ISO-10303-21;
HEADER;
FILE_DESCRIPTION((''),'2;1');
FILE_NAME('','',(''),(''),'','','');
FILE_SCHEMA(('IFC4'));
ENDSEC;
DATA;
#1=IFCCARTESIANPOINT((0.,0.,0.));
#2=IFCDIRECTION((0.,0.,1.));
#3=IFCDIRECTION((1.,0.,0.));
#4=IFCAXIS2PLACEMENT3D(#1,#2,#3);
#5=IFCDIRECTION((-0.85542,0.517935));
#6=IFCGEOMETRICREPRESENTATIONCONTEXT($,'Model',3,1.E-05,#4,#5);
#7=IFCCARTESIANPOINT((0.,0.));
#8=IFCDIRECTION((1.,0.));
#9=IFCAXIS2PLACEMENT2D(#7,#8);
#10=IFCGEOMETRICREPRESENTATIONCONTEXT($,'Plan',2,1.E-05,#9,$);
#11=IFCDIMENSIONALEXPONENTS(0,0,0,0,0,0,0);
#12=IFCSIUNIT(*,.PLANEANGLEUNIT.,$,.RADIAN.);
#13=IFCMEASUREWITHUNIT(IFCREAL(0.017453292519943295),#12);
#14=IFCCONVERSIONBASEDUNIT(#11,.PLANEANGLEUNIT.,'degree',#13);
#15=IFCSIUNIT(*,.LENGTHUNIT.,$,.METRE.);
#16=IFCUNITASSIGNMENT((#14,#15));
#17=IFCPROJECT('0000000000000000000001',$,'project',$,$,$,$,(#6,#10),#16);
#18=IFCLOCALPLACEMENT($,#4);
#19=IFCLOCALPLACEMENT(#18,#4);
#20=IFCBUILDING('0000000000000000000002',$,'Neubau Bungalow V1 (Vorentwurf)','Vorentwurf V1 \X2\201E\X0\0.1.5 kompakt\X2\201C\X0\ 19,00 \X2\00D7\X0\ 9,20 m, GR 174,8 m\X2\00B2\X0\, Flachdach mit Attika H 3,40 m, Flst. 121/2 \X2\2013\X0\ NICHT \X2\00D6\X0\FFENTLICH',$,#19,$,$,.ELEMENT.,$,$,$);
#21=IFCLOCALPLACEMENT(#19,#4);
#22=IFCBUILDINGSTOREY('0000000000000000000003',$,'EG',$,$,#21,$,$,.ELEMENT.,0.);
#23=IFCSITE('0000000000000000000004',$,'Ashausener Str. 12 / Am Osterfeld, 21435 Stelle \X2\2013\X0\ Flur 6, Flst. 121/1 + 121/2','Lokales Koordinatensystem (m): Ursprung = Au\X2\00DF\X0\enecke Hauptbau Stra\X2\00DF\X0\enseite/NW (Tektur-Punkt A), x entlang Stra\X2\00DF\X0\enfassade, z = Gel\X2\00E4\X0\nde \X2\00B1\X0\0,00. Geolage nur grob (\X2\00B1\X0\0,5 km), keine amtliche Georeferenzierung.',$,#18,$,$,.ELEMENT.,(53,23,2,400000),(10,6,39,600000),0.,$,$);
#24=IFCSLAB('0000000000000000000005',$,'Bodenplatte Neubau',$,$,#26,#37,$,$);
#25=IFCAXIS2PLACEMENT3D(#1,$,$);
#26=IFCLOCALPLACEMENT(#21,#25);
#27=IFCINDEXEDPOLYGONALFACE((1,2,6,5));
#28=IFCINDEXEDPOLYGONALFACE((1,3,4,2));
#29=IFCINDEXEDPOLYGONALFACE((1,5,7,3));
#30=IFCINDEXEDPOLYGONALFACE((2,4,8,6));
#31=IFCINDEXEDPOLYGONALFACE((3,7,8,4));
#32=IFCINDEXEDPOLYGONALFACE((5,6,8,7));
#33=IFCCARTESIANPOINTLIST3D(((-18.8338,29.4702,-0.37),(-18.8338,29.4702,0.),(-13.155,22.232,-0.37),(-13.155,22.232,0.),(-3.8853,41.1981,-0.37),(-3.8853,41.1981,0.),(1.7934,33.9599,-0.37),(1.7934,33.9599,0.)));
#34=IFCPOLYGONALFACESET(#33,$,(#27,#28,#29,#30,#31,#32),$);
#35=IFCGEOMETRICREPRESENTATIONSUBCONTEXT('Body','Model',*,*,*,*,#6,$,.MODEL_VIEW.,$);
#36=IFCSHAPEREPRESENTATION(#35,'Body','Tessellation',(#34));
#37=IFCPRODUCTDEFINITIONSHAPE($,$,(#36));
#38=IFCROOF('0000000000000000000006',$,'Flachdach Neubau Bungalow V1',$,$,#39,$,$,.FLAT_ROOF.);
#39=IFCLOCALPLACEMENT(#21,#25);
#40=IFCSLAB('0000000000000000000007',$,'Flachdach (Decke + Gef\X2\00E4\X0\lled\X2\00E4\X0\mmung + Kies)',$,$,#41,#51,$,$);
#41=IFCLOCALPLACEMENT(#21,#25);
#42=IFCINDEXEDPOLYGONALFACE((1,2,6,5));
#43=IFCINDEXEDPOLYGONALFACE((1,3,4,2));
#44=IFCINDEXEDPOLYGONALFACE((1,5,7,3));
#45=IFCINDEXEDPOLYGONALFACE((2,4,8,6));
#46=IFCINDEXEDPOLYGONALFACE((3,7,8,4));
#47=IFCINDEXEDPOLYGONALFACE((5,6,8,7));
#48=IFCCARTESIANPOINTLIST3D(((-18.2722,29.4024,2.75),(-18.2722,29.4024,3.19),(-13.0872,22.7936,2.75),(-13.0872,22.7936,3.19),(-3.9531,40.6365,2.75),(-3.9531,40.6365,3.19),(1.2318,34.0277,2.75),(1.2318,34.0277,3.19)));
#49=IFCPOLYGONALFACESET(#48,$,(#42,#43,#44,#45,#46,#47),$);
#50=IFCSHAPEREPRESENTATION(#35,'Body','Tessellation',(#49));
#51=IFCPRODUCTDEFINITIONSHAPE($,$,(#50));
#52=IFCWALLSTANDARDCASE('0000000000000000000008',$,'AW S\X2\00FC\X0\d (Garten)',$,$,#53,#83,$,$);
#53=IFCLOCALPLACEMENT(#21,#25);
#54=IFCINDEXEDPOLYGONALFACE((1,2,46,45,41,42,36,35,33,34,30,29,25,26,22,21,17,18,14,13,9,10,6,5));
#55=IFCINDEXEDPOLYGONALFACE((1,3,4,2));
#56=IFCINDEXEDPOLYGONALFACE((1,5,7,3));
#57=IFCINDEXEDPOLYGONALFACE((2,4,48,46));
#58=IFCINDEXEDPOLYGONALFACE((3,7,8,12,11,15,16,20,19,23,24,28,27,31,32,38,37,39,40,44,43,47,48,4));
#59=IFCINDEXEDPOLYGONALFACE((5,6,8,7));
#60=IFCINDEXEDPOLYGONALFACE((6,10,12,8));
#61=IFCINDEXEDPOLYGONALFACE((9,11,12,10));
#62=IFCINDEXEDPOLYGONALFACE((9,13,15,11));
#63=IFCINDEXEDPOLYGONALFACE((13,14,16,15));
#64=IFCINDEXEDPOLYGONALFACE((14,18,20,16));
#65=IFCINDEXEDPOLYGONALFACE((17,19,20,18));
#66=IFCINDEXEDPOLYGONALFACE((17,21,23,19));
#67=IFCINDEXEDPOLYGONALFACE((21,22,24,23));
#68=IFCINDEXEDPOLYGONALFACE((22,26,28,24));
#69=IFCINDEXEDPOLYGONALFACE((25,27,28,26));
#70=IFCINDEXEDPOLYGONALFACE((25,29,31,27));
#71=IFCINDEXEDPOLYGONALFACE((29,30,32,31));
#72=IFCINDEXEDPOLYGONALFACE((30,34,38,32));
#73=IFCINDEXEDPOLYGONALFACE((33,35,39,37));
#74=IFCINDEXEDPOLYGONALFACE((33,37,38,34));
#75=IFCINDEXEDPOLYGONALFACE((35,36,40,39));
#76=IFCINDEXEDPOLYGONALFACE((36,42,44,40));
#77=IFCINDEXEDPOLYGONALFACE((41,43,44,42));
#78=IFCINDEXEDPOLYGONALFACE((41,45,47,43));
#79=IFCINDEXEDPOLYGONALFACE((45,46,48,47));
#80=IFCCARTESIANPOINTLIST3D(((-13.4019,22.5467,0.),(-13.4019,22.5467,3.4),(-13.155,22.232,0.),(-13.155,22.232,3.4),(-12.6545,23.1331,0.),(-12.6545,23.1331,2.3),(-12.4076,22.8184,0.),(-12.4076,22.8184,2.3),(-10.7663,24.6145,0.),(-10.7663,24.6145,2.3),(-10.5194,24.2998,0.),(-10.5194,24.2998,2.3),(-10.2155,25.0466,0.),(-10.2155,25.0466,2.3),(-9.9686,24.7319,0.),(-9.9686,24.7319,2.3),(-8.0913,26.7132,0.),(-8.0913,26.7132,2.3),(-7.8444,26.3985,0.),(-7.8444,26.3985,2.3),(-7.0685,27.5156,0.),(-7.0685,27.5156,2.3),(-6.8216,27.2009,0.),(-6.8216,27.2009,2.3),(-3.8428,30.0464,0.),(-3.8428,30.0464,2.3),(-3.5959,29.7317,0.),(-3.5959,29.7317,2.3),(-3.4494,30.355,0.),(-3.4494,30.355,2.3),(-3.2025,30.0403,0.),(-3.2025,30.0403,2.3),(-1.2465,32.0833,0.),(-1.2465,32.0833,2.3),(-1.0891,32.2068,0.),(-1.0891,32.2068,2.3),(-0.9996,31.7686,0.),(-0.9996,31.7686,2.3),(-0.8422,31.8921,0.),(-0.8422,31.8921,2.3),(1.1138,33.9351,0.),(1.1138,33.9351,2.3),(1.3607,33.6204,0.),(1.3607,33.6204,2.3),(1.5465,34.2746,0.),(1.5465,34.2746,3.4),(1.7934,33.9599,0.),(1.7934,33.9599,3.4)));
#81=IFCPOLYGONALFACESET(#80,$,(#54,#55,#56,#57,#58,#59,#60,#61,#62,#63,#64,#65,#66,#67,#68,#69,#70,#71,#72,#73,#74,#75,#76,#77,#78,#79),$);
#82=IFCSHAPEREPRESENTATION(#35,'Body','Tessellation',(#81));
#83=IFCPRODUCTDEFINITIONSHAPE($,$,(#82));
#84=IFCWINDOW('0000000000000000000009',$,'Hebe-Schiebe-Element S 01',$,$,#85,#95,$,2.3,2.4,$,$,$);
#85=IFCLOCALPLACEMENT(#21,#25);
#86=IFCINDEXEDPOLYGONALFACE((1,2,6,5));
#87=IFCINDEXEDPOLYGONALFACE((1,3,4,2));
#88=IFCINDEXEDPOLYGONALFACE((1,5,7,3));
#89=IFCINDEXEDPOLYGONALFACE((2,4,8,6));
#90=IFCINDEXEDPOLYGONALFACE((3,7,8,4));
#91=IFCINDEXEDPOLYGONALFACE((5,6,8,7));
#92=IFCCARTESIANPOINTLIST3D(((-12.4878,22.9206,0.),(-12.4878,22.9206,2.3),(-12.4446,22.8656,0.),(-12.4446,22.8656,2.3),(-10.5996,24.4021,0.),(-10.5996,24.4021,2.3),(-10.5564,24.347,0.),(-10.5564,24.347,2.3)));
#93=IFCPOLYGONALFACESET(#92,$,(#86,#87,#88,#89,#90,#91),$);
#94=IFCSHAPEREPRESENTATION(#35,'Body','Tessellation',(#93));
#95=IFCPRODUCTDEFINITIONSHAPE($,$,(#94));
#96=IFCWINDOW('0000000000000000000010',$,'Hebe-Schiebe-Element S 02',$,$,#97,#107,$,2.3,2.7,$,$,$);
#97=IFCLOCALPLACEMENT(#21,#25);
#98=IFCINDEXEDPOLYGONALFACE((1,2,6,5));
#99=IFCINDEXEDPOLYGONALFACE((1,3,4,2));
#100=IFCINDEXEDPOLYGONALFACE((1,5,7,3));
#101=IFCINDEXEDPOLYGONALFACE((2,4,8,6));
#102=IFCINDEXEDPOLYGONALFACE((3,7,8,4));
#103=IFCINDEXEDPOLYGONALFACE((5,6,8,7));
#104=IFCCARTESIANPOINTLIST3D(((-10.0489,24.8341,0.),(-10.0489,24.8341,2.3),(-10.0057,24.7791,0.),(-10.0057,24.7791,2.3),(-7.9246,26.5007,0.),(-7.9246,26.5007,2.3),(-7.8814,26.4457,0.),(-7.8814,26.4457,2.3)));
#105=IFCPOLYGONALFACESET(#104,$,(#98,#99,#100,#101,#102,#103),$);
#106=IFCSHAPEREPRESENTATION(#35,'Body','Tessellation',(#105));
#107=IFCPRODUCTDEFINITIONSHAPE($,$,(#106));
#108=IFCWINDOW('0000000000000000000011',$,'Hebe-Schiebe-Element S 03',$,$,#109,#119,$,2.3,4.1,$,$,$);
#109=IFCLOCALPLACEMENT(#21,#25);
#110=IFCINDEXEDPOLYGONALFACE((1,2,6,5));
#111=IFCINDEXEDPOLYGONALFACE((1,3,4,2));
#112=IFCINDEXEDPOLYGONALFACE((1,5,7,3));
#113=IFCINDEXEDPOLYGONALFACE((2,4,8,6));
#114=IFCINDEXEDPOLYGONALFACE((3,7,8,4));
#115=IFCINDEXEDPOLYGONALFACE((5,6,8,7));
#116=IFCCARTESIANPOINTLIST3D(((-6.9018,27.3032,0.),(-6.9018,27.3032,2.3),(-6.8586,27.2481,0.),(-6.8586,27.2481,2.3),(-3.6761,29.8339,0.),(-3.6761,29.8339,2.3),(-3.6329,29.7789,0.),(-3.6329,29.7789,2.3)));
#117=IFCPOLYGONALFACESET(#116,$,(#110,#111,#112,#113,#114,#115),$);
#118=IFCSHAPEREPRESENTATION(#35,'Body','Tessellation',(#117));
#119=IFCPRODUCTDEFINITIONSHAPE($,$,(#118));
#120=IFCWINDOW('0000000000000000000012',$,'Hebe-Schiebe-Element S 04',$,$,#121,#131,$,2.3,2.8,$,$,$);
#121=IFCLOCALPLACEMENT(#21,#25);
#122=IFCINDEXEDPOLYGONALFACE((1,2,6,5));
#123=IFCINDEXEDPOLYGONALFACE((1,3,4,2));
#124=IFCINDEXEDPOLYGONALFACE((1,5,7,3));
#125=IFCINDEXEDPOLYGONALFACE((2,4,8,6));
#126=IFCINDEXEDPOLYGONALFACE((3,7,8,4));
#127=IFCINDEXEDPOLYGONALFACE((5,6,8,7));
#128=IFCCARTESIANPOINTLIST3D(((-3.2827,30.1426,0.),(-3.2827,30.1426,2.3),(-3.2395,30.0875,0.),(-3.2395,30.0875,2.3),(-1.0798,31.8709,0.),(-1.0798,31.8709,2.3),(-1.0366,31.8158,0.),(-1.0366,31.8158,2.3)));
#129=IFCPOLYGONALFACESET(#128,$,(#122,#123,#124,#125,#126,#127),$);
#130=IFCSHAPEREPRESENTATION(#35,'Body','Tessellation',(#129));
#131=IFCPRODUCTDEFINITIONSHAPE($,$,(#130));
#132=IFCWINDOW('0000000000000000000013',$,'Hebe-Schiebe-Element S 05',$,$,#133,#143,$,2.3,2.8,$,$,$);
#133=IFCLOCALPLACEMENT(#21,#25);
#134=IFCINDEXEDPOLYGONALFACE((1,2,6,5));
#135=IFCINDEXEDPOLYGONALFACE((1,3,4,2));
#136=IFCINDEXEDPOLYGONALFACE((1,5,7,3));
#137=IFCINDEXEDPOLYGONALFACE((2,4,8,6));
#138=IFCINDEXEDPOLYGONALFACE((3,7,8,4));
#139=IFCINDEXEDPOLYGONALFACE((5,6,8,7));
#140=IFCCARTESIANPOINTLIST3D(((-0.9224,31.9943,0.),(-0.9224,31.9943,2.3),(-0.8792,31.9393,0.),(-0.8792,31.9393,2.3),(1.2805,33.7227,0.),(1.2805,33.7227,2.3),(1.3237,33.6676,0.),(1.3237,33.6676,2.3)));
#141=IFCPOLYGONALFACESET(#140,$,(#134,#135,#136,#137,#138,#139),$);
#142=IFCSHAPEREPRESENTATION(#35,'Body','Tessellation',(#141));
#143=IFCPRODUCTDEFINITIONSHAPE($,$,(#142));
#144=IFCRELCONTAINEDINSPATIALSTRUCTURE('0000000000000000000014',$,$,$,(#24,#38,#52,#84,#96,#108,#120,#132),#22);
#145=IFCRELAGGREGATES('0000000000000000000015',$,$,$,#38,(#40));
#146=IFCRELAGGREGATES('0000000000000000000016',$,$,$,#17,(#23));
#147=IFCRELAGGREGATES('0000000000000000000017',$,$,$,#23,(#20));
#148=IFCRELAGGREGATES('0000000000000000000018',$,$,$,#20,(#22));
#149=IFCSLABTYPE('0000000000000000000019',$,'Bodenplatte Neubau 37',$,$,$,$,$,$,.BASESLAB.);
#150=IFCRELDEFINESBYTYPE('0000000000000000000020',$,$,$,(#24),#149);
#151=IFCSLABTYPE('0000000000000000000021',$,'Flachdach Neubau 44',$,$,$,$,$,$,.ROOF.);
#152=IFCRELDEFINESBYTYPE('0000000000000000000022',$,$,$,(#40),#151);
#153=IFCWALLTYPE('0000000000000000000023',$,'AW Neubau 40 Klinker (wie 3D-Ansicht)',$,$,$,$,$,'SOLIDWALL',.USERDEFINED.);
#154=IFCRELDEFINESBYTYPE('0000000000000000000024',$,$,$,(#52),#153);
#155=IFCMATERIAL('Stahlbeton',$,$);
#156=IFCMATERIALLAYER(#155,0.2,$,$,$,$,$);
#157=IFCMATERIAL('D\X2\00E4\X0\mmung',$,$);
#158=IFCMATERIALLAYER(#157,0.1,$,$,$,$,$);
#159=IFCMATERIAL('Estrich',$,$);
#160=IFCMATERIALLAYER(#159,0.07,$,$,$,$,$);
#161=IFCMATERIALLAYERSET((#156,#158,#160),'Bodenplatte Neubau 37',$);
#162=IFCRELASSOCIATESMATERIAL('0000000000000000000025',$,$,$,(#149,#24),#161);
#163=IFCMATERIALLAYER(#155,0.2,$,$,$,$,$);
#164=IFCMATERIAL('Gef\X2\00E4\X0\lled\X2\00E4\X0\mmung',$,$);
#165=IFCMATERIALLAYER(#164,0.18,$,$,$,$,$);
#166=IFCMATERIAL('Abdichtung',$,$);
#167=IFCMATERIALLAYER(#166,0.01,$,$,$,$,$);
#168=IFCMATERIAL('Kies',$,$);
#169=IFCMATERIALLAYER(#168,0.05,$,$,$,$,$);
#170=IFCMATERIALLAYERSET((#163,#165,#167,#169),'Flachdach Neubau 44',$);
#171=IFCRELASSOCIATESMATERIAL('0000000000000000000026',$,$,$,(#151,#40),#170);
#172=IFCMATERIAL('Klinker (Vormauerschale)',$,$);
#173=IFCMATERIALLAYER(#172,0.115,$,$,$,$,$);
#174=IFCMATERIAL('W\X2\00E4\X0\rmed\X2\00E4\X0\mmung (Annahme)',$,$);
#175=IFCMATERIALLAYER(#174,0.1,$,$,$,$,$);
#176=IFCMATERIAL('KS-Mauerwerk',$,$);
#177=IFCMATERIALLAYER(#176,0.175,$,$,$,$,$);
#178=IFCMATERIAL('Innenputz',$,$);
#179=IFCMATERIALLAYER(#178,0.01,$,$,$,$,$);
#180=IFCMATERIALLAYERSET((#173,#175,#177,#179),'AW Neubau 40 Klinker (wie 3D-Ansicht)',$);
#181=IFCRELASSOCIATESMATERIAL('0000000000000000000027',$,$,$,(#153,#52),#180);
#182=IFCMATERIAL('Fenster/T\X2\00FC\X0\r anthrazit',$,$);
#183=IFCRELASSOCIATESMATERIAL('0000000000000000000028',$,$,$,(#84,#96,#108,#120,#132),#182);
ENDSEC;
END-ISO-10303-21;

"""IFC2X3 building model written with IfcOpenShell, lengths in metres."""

from ifc_helpers import new_model, entity, si_unit, converted_unit, direction, frame, origin_with_axes, origin_2d_with_axis, place, context, subcontext, project, spatial, polyline, outline, extrude, material, layer, layer_set, layer_usage, type_object, element, fill, aggregate, save


model = new_model("IFC2X3")

# Units and contexts
model_context = context("Model", 3, precision=1e-05, world=origin_with_axes(), true_north=direction((-0.85542, 0.517935)))
plan_context = context("Plan", 2, precision=1e-05, world=origin_2d_with_axis())
body_context = subcontext(model_context, "Body", "Model", "MODEL_VIEW")
ifc_project = project(units=[converted_unit("PLANEANGLEUNIT", "degree", entity("IfcReal", 0.017453292519943295), si_unit("PLANEANGLEUNIT", "RADIAN"), dimensions=[0, 0, 0, 0, 0, 0, 0]), si_unit("LENGTHUNIT", "METRE")], contexts=[model_context, plan_context])

# Site, building, storey
site_placement = place(None, origin_with_axes())
site = spatial("IfcSite", under=ifc_project, at=site_placement, Name="Ashausener Str. 12 / Am Osterfeld, 21435 Stelle – Flur 6, Flst. 121/1 + 121/2", Description="Lokales Koordinatensystem (m): Ursprung = Außenecke Hauptbau Straßenseite/NW (Tektur-Punkt A), x entlang Straßenfassade, z = Gelände ±0,00. Geolage nur grob (±0,5 km), keine amtliche Georeferenzierung.", CompositionType="ELEMENT", RefLatitude=(53, 23, 2, 400000), RefLongitude=(10, 6, 39, 600000), RefElevation=0.0)
building_placement = place(site_placement, origin_with_axes())
building = spatial("IfcBuilding", under=site, at=building_placement, Name="Neubau Bungalow V1 (Vorentwurf)", Description="Vorentwurf V1 „0.1.5 kompakt“ 19,00 × 9,20 m, GR 174,8 m², Flachdach mit Attika H 3,40 m, Flst. 121/2 – NICHT ÖFFENTLICH", CompositionType="ELEMENT")
storey_placement = place(building_placement, origin_with_axes())
storey = spatial("IfcBuildingStorey", under=building, at=storey_placement, Name="EG", CompositionType="ELEMENT", Elevation=0.0)

# Slab
ifc_material_1 = material(Name="Stahlbeton")
ifc_layer_1 = layer(ifc_material_1, 0.2)
ifc_material_2 = material(Name="Dämmung")
ifc_layer_2 = layer(ifc_material_2, 0.1)
ifc_material_3 = material(Name="Estrich")
ifc_layer_3 = layer(ifc_material_3, 0.07)
ifc_layer_set_1 = layer_set([ifc_layer_1, ifc_layer_2, ifc_layer_3], Name="Bodenplatte Neubau 37")
ifc_layer_usage_1 = layer_usage(ifc_layer_set_1, "AXIS3", "POSITIVE", 0.0)
slab_type_1 = type_object("IfcSlabType", Name="Bodenplatte Neubau 37", PredefinedType="BASESLAB", material=ifc_layer_set_1)
slab_1_placement = place(storey_placement, origin_with_axes())
element("IfcSlab", 1, at=slab_1_placement, inside=storey, type_object=slab_type_1, material=ifc_layer_usage_1, Name="Bodenplatte Neubau", context=body_context, shape_type="SweptSolid", body=[
    extrude(outline(polyline([(-13.155, 22.232), (1.7934, 33.9599), (-3.8853, 41.1981), (-18.8338, 29.4702), (-13.155, 22.232)])), frame((0.0, 0.0, -0.37)), (0.0, 0.0, 1.0), 0.37),
])

# Roof, slab
roof_placement = place(storey_placement, origin_with_axes())
roof = element("IfcRoof", 2, at=roof_placement, inside=storey, Name="Flachdach Neubau Bungalow V1", ShapeType="FLAT_ROOF")
ifc_layer_4 = layer(ifc_material_1, 0.2)
ifc_material_4 = material(Name="Gefälledämmung")
ifc_layer_5 = layer(ifc_material_4, 0.18)
ifc_material_5 = material(Name="Abdichtung")
ifc_layer_6 = layer(ifc_material_5, 0.01)
ifc_material_6 = material(Name="Kies")
ifc_layer_7 = layer(ifc_material_6, 0.05)
ifc_layer_set_2 = layer_set([ifc_layer_4, ifc_layer_5, ifc_layer_6, ifc_layer_7], Name="Flachdach Neubau 44")
ifc_layer_usage_2 = layer_usage(ifc_layer_set_2, "AXIS3", "POSITIVE", 0.0)
slab_type_2 = type_object("IfcSlabType", Name="Flachdach Neubau 44", PredefinedType="ROOF", material=ifc_layer_set_2)
slab_2_placement = place(roof_placement, origin_with_axes())
slab_2 = element("IfcSlab", 3, at=slab_2_placement, type_object=slab_type_2, material=ifc_layer_usage_2, Name="Flachdach (Decke + Gefälledämmung + Kies)", context=body_context, shape_type="SweptSolid", body=[
    extrude(outline(polyline([(-13.0872, 22.7936), (1.2318, 34.0277), (-3.9531, 40.6365), (-18.2722, 29.4024), (-13.0872, 22.7936)])), frame((0.0, 0.0, 2.75)), (0.0, 0.0, 1.0), 0.44),
])
aggregate(roof, [slab_2])

# Wall, openings, windows
ifc_material_7 = material(Name="Klinker (Vormauerschale)")
ifc_layer_8 = layer(ifc_material_7, 0.115)
ifc_material_8 = material(Name="Wärmedämmung (Annahme)")
ifc_layer_9 = layer(ifc_material_8, 0.1)
ifc_material_9 = material(Name="KS-Mauerwerk")
ifc_layer_10 = layer(ifc_material_9, 0.175)
ifc_material_10 = material(Name="Innenputz")
ifc_layer_11 = layer(ifc_material_10, 0.01)
ifc_layer_set_3 = layer_set([ifc_layer_8, ifc_layer_9, ifc_layer_10, ifc_layer_11], Name="AW Neubau 40 Klinker (wie 3D-Ansicht)")
ifc_layer_usage_3 = layer_usage(ifc_layer_set_3, "AXIS2", "POSITIVE", 0.0)
wall_type_1 = type_object("IfcWallType", Name="AW Neubau 40 Klinker (wie 3D-Ansicht)", ElementType="SOLIDWALL", PredefinedType="USERDEFINED", material=ifc_layer_set_3)
wall_1_placement = place(storey_placement, frame((-13.155, 22.232, 0.0), z_axis=(0.0, 0.0, 1.0), x_axis=(0.786761, 0.617258, 0.0)))
wall_1 = element("IfcWallStandardCase", 4, at=wall_1_placement, inside=storey, type_object=wall_type_1, material=ifc_layer_usage_3, Name="AW Süd (Garten)", context=body_context, shape_type="SweptSolid", body=[
    extrude(outline(polyline([(0.0, 0.0), (0.0, 0.4), (19.0, 0.4), (19.0, 0.0), (0.0, 0.0)])), origin_with_axes(), (0.0, 0.0, 1.0), 3.4),
])
opening_1_placement = place(wall_1_placement, frame((0.95, -0.1, 0.0), z_axis=(0.0, 0.0, 1.0), x_axis=(1.0, 0.0, 0.0)))
opening_1 = element("IfcOpeningElement", 5, at=opening_1_placement, cuts=wall_1, context=body_context, shape_type="SweptSolid", body=[
    extrude(outline(polyline([(0.0, 0.0), (0.0, 0.6), (2.4, 0.6), (2.4, 0.0), (0.0, 0.0)])), origin_with_axes(), (0.0, 0.0, 1.0), 2.3),
])
opening_2_placement = place(wall_1_placement, frame((4.05, -0.1, 0.0), z_axis=(0.0, 0.0, 1.0), x_axis=(1.0, 0.0, 0.0)))
opening_2 = element("IfcOpeningElement", 6, at=opening_2_placement, cuts=wall_1, context=body_context, shape_type="SweptSolid", body=[
    extrude(outline(polyline([(0.0, 0.0), (0.0, 0.6), (2.7, 0.6), (2.7, 0.0), (0.0, 0.0)])), origin_with_axes(), (0.0, 0.0, 1.0), 2.3),
])
opening_3_placement = place(wall_1_placement, frame((8.05, -0.1, 0.0), z_axis=(0.0, 0.0, 1.0), x_axis=(1.0, 0.0, 0.0)))
opening_3 = element("IfcOpeningElement", 7, at=opening_3_placement, cuts=wall_1, context=body_context, shape_type="SweptSolid", body=[
    extrude(outline(polyline([(0.0, 0.0), (0.0, 0.6), (4.1, 0.6), (4.1, 0.0), (0.0, 0.0)])), origin_with_axes(), (0.0, 0.0, 1.0), 2.3),
])
opening_4_placement = place(wall_1_placement, frame((12.65, -0.1, 0.0), z_axis=(0.0, 0.0, 1.0), x_axis=(1.0, 0.0, 0.0)))
opening_4 = element("IfcOpeningElement", 8, at=opening_4_placement, cuts=wall_1, context=body_context, shape_type="SweptSolid", body=[
    extrude(outline(polyline([(0.0, 0.0), (0.0, 0.6), (2.8, 0.6), (2.8, 0.0), (0.0, 0.0)])), origin_with_axes(), (0.0, 0.0, 1.0), 2.3),
])
opening_5_placement = place(wall_1_placement, frame((15.65, -0.1, 0.0), z_axis=(0.0, 0.0, 1.0), x_axis=(1.0, 0.0, 0.0)))
opening_5 = element("IfcOpeningElement", 9, at=opening_5_placement, cuts=wall_1, context=body_context, shape_type="SweptSolid", body=[
    extrude(outline(polyline([(0.0, 0.0), (0.0, 0.6), (2.8, 0.6), (2.8, 0.0), (0.0, 0.0)])), origin_with_axes(), (0.0, 0.0, 1.0), 2.3),
])
ifc_material_11 = material(Name="Fenster/Tür anthrazit")
window_1_placement = place(storey_placement, frame((-12.4446, 22.8656, 0.0), z_axis=(0.0, 0.0, 1.0), x_axis=(0.786761, 0.617258, 0.0)))
window_1 = element("IfcWindow", 10, at=window_1_placement, inside=storey, material=ifc_material_11, Name="Hebe-Schiebe-Element S 01", OverallHeight=2.3, OverallWidth=2.4, context=body_context, shape_type="SweptSolid", body=[
    extrude(outline(polyline([(0.0, 0.0), (0.0, 0.07), (2.4, 0.07), (2.4, 0.0), (0.0, 0.0)])), origin_with_axes(), (0.0, 0.0, 1.0), 2.3),
])
fill(opening_1, window_1)
window_2_placement = place(storey_placement, frame((-10.0057, 24.7791, 0.0), z_axis=(0.0, 0.0, 1.0), x_axis=(0.786761, 0.617258, 0.0)))
window_2 = element("IfcWindow", 11, at=window_2_placement, inside=storey, material=ifc_material_11, Name="Hebe-Schiebe-Element S 02", OverallHeight=2.3, OverallWidth=2.7, context=body_context, shape_type="SweptSolid", body=[
    extrude(outline(polyline([(0.0, 0.0), (0.0, 0.07), (2.7, 0.07), (2.7, 0.0), (0.0, 0.0)])), origin_with_axes(), (0.0, 0.0, 1.0), 2.3),
])
fill(opening_2, window_2)
window_3_placement = place(storey_placement, frame((-6.8586, 27.2481, 0.0), z_axis=(0.0, 0.0, 1.0), x_axis=(0.786761, 0.617258, 0.0)))
window_3 = element("IfcWindow", 12, at=window_3_placement, inside=storey, material=ifc_material_11, Name="Hebe-Schiebe-Element S 03", OverallHeight=2.3, OverallWidth=4.1, context=body_context, shape_type="SweptSolid", body=[
    extrude(outline(polyline([(0.0, 0.0), (0.0, 0.07), (4.1, 0.07), (4.1, 0.0), (0.0, 0.0)])), origin_with_axes(), (0.0, 0.0, 1.0), 2.3),
])
fill(opening_3, window_3)
window_4_placement = place(storey_placement, frame((-3.2395, 30.0875, 0.0), z_axis=(0.0, 0.0, 1.0), x_axis=(0.786761, 0.617258, 0.0)))
window_4 = element("IfcWindow", 13, at=window_4_placement, inside=storey, material=ifc_material_11, Name="Hebe-Schiebe-Element S 04", OverallHeight=2.3, OverallWidth=2.8, context=body_context, shape_type="SweptSolid", body=[
    extrude(outline(polyline([(0.0, 0.0), (0.0, 0.07), (2.8, 0.07), (2.8, 0.0), (0.0, 0.0)])), origin_with_axes(), (0.0, 0.0, 1.0), 2.3),
])
fill(opening_4, window_4)
window_5_placement = place(storey_placement, frame((-0.8792, 31.9393, 0.0), z_axis=(0.0, 0.0, 1.0), x_axis=(0.786761, 0.617258, 0.0)))
window_5 = element("IfcWindow", 14, at=window_5_placement, inside=storey, material=ifc_material_11, Name="Hebe-Schiebe-Element S 05", OverallHeight=2.3, OverallWidth=2.8, context=body_context, shape_type="SweptSolid", body=[
    extrude(outline(polyline([(0.0, 0.0), (0.0, 0.07), (2.8, 0.07), (2.8, 0.0), (0.0, 0.0)])), origin_with_axes(), (0.0, 0.0, 1.0), 2.3),
])
fill(opening_5, window_5)

save(model, "model.ifc")
